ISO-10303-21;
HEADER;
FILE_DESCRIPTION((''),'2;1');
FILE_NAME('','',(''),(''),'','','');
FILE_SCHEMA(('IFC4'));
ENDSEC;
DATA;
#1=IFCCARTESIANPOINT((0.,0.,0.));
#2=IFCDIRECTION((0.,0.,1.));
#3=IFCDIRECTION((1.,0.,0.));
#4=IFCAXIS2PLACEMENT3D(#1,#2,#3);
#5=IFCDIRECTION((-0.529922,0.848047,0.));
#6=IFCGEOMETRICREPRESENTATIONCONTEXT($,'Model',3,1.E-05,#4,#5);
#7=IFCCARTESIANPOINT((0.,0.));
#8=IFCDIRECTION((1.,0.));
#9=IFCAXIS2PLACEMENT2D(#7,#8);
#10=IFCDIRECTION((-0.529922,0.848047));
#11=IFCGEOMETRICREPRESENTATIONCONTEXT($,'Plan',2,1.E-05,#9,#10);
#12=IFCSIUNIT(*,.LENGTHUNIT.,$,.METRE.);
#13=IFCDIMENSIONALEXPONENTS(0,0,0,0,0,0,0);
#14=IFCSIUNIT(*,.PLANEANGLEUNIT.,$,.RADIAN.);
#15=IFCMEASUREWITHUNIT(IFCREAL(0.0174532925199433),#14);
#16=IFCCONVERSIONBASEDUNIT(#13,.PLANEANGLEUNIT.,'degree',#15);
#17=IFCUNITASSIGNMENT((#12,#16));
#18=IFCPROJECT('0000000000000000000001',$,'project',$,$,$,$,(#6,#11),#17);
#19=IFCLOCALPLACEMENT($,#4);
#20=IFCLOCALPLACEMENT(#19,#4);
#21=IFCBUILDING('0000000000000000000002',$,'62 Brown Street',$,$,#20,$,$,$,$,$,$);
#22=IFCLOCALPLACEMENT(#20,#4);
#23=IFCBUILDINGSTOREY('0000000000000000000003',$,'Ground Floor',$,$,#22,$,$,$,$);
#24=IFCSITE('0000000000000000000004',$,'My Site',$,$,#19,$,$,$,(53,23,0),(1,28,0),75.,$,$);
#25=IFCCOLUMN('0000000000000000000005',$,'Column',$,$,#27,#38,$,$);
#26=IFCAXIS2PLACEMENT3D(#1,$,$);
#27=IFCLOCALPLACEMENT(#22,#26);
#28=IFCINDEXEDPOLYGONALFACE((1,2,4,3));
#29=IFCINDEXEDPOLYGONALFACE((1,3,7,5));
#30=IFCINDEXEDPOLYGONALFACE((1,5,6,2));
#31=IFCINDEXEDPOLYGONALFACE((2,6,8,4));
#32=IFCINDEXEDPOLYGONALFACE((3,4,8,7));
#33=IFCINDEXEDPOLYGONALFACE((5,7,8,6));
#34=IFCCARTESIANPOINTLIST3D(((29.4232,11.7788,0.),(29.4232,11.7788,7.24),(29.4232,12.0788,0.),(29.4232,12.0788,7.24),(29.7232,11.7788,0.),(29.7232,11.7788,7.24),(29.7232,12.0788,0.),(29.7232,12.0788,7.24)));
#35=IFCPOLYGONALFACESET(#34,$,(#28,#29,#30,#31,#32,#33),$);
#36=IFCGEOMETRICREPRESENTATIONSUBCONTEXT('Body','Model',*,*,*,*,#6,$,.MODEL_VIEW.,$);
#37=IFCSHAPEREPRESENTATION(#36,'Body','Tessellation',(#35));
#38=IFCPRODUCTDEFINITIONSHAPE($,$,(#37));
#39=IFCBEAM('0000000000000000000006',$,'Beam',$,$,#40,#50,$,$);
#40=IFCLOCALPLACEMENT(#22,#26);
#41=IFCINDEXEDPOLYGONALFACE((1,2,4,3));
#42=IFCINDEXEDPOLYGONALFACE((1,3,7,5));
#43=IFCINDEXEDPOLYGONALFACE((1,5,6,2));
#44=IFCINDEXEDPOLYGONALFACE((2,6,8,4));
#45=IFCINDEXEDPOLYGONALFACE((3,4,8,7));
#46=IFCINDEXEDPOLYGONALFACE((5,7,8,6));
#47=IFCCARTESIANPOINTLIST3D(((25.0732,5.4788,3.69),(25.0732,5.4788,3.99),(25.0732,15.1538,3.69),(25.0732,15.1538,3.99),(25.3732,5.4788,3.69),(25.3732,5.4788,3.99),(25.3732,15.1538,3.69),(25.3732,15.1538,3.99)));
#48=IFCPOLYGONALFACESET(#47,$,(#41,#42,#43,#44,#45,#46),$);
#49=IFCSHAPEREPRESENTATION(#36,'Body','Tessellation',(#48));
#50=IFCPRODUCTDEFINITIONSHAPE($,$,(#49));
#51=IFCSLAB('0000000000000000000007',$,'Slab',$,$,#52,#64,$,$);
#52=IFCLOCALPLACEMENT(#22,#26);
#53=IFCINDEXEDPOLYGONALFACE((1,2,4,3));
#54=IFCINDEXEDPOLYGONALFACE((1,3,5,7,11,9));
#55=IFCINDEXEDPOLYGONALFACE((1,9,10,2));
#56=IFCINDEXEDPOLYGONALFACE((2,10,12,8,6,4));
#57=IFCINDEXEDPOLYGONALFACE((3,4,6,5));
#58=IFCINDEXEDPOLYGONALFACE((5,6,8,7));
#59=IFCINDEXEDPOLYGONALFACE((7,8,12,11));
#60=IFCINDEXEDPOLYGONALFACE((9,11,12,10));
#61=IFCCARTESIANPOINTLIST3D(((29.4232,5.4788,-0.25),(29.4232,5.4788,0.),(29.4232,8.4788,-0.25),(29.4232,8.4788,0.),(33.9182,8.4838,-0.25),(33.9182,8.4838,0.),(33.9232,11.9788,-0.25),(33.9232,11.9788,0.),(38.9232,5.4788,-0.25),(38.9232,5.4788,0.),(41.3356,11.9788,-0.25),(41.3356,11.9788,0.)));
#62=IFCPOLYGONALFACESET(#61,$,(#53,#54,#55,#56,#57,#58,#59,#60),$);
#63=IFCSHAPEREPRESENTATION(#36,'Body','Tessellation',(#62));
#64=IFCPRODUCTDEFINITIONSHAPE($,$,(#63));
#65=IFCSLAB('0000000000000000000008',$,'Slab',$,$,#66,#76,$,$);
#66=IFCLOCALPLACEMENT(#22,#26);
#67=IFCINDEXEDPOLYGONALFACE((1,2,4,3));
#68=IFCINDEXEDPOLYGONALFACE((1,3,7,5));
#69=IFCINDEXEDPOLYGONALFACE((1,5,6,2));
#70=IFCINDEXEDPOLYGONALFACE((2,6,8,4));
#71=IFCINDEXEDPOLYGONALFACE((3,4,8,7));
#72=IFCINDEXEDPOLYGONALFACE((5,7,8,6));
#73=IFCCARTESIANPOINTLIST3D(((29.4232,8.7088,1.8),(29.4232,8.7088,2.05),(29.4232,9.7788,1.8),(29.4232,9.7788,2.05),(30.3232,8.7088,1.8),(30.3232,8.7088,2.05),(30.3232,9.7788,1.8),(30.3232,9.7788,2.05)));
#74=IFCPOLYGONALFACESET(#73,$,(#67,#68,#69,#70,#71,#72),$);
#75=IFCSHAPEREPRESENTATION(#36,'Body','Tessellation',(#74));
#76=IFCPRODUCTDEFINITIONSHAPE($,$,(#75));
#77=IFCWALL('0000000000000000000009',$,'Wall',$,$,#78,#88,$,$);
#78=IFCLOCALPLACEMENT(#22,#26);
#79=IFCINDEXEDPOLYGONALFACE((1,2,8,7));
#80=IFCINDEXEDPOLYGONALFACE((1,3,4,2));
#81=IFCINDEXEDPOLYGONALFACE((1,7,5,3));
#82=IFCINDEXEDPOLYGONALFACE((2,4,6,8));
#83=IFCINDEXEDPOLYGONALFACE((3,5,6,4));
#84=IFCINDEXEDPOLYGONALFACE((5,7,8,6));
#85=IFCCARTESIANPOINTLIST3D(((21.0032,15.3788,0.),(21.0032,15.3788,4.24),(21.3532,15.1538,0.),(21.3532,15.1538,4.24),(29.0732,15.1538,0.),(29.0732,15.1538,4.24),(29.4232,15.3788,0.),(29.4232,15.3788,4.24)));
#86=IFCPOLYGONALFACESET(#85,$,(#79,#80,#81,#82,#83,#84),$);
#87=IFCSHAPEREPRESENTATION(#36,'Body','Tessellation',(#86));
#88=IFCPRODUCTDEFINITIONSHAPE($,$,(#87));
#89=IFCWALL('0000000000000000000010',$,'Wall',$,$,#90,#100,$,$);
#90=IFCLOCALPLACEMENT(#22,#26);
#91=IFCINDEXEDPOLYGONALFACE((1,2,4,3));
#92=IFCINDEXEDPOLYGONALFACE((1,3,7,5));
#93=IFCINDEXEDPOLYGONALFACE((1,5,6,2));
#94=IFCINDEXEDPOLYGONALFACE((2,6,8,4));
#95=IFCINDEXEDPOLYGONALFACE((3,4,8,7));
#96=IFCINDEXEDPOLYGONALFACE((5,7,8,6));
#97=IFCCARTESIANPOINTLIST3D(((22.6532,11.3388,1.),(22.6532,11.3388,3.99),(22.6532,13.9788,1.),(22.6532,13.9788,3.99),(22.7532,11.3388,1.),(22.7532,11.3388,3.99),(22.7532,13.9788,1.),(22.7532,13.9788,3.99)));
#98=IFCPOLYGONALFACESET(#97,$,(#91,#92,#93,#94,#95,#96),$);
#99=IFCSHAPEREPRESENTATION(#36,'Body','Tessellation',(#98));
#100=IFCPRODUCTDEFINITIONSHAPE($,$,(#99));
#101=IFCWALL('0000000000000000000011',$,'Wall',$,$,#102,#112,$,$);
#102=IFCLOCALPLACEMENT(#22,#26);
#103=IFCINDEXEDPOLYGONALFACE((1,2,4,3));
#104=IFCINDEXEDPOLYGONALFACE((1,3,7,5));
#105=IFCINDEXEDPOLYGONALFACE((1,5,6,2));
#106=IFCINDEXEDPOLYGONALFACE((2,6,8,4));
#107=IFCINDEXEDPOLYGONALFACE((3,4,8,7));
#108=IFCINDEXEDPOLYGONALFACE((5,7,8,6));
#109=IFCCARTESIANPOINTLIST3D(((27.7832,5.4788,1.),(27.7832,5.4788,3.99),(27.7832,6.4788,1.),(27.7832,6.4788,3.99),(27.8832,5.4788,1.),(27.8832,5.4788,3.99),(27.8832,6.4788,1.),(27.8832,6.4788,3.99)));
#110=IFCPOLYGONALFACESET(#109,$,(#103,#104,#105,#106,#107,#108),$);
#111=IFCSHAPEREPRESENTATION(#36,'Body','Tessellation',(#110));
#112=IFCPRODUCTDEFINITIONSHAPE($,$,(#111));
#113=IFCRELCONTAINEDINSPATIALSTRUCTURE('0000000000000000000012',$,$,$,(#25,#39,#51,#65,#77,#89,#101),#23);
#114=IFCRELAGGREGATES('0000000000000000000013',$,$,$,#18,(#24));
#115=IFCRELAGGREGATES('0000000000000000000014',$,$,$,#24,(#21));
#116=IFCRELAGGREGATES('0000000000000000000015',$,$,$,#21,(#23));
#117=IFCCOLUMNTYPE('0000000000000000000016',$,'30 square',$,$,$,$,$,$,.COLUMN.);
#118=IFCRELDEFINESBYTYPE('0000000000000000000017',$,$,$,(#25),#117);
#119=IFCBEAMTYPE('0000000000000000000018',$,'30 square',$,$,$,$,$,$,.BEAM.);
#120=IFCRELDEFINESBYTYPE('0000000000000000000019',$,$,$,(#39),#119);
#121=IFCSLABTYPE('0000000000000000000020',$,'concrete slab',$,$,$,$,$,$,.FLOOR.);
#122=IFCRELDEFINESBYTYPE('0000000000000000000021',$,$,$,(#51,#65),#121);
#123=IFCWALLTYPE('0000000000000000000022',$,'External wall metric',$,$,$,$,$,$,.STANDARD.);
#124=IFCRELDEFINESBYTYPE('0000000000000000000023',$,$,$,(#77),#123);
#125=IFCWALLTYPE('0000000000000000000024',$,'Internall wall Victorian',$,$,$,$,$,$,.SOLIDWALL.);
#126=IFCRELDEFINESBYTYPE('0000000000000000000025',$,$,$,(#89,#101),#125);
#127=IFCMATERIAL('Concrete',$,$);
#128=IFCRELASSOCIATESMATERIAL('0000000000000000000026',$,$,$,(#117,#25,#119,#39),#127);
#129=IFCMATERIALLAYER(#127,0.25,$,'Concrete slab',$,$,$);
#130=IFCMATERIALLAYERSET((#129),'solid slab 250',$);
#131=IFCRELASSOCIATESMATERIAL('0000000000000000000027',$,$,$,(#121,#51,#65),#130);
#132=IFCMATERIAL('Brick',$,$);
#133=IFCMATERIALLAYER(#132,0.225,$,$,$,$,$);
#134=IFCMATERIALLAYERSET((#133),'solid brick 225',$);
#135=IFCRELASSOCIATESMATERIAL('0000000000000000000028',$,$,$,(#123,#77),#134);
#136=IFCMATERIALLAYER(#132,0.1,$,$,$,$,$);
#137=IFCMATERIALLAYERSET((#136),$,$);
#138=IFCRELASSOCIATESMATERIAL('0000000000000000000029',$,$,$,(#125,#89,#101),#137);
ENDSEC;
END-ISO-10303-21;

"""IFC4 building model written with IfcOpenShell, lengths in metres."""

from ifc_helpers import new_model, entity, si_unit, converted_unit, direction, frame, origin_with_axes, origin_2d_with_axis, place, context, subcontext, project, spatial, line, indexed_curve, rectangle, outline, extrude, clip, halfspace, material, layer, layer_set, layer_usage, material_profile, profile_set, profile_usage, type_object, element, save


model = new_model("IFC4")

# Units and contexts
model_context = context("Model", 3, precision=1e-05, world=origin_with_axes(), true_north=direction((-0.529922, 0.848047, 0.0)))
plan_context = context("Plan", 2, precision=1e-05, world=origin_2d_with_axis(), true_north=direction((-0.529922, 0.848047)))
body_context_1 = subcontext(model_context, "Body", "Model", "MODEL_VIEW")
ifc_project = project(units=[si_unit("LENGTHUNIT", "METRE"), converted_unit("PLANEANGLEUNIT", "degree", entity("IfcReal", 0.0174532925199433), si_unit("PLANEANGLEUNIT", "RADIAN"), dimensions=[0, 0, 0, 0, 0, 0, 0])], contexts=[model_context, plan_context])

# Site, building, storey
site_placement = place(None, origin_with_axes())
site = spatial("IfcSite", under=ifc_project, at=site_placement, Name="My Site", RefLatitude=(53, 23, 0), RefLongitude=(1, 28, 0), RefElevation=75.0)
building_placement = place(site_placement, origin_with_axes())
building = spatial("IfcBuilding", under=site, at=building_placement, Name="62 Brown Street")
storey_placement = place(building_placement, origin_with_axes())
storey = spatial("IfcBuildingStorey", under=building, at=storey_placement, Name="Ground Floor")

# Column
ifc_material_1 = material(Name="Concrete")
ifc_material_profile_1 = material_profile(ifc_material_1, rectangle(XDim=0.3, YDim=0.3))
ifc_profile_set_1 = profile_set([ifc_material_profile_1])
ifc_profile_usage_1 = profile_usage(ifc_profile_set_1, cardinal=5)
column_type = type_object("IfcColumnType", Name="30 square", PredefinedType="COLUMN", material=ifc_profile_set_1)
column_1_placement = place(storey_placement, frame((29.5732, 11.9288, 0.0), z_axis=(0.0, 0.0, 1.0), x_axis=(1.0, 0.0, 0.0)))
element("IfcColumn", 1, at=column_1_placement, inside=storey, type_object=column_type, material=ifc_profile_usage_1, Name="Column", context=body_context_1, shape_type="SweptSolid", body=[
    extrude(rectangle(XDim=0.3, YDim=0.3), origin_with_axes(), (0.0, 0.0, 1.0), 7.24),
])

# Beam
ifc_material_profile_2 = material_profile(ifc_material_1, rectangle(XDim=0.3, YDim=0.3))
ifc_profile_set_2 = profile_set([ifc_material_profile_2])
ifc_profile_usage_2 = profile_usage(ifc_profile_set_2, cardinal=5)
beam_type = type_object("IfcBeamType", Name="30 square", PredefinedType="BEAM", material=ifc_profile_set_2)
beam_placement = place(storey_placement, frame((25.2232, 5.4788, 3.84), z_axis=(0.0, 1.0, 0.0), x_axis=(-1.0, 0.0, 0.0)))
element("IfcBeam", 2, at=beam_placement, inside=storey, type_object=beam_type, material=ifc_profile_usage_2, Name="Beam", context=body_context_1, shape_type="SweptSolid", body=[
    extrude(rectangle(XDim=0.3, YDim=0.3), origin_with_axes(), (0.0, 0.0, 1.0), 9.675),
])

# Slabs
ifc_layer_1 = layer(ifc_material_1, 0.25, Name="Concrete slab")
ifc_layer_set_1 = layer_set([ifc_layer_1], Name="solid slab 250")
ifc_layer_usage_1 = layer_usage(ifc_layer_set_1, "AXIS3", "POSITIVE", 0.0)
slab_type_1 = type_object("IfcSlabType", Name="concrete slab", PredefinedType="FLOOR", material=ifc_layer_set_1)
slab_1_placement = place(storey_placement, frame((29.4232, 5.4788, -0.25), z_axis=(0.0, 0.0, 1.0), x_axis=(1.0, 0.0, 0.0)))
element("IfcSlab", 3, at=slab_1_placement, inside=storey, type_object=slab_type_1, material=ifc_layer_usage_1, Name="Slab", context=body_context_1, shape_type="SweptSolid", body=[
    extrude(outline(indexed_curve([(0.0, 0.0), (9.5, 0.0), (11.9124, 6.5), (0.0, 3.0), (4.5, 6.5), (4.495, 3.005)], segments=[line(1, 2), line(2, 3), line(3, 5), line(5, 6), line(6, 4), line(4, 1)], self_intersect=False)), None, (0.0, 0.0, 1.0), 0.25),
])
ifc_layer_usage_2 = layer_usage(ifc_layer_set_1, "AXIS3", "POSITIVE", 0.0)
slab_2_placement = place(storey_placement, frame((29.4232, 8.7088, 1.8), z_axis=(0.0, 0.0, 1.0), x_axis=(1.0, 0.0, 0.0)))
element("IfcSlab", 4, at=slab_2_placement, inside=storey, type_object=slab_type_1, material=ifc_layer_usage_2, Name="Slab", context=body_context_1, shape_type="SweptSolid", body=[
    extrude(outline(indexed_curve([(0.9, 1.07), (0.9, 0.0), (0.0, 0.0), (0.0, 1.07)], segments=[line(3, 2), line(2, 1), line(1, 4), line(4, 3)], self_intersect=False)), None, (0.0, 0.0, 1.0), 0.25),
])

# Walls
ifc_material_2 = material(Name="Brick")
ifc_layer_2 = layer(ifc_material_2, 0.225)
ifc_layer_set_2 = layer_set([ifc_layer_2], Name="solid brick 225")
wall_type_1 = type_object("IfcWallType", Name="External wall metric", PredefinedType="STANDARD", material=ifc_layer_set_2)
ifc_layer_usage_3 = layer_usage(ifc_layer_set_2, "AXIS2", "POSITIVE", 0.0)
wall_1_placement = place(storey_placement, frame((29.4232, 15.3788, 0.0), z_axis=(0.0, 0.0, 1.0), x_axis=(-1.0, 0.0, 0.0)))
element("IfcWall", 5, at=wall_1_placement, inside=storey, type_object=wall_type_1, material=ifc_layer_usage_3, Name="Wall", context=body_context_1, shape_type="Clipping", body=[
    clip(clip(extrude(outline(indexed_curve([(0.0, 0.0), (0.0, 0.225), (8.42, 0.225), (8.42, 0.0), (0.0, 0.0)], self_intersect=False)), origin_with_axes(), (0.0, 0.0, 1.0), 4.24), halfspace(frame((8.42, 0.0, 0.0), z_axis=(0.540756, 0.841179, 0.0), x_axis=(-0.841179, 0.540756, 0.0)), False)), halfspace(frame((0.0, 0.0, 0.0), z_axis=(-0.540758, 0.841178, 0.0), x_axis=(0.841178, 0.540758, 0.0)), False)),
])
ifc_layer_3 = layer(ifc_material_2, 0.1)
ifc_layer_set_3 = layer_set([ifc_layer_3])
ifc_layer_usage_4 = layer_usage(ifc_layer_set_3, "AXIS2", "POSITIVE", 0.0)
wall_type_2 = type_object("IfcWallType", Name="Internall wall Victorian", PredefinedType="SOLIDWALL", material=ifc_layer_set_3)
wall_2_placement = place(storey_placement, frame((22.7532, 11.3388, 1.0), z_axis=(0.0, 0.0, 1.0), x_axis=(0.0, 1.0, 0.0)))
element("IfcWall", 6, at=wall_2_placement, inside=storey, type_object=wall_type_2, material=ifc_layer_usage_4, Name="Wall", context=body_context_1, shape_type="SweptSolid", body=[
    extrude(outline(indexed_curve([(0.0, 0.0), (0.0, 0.1), (2.64, 0.1), (2.64, 0.0), (0.0, 0.0)], self_intersect=False)), origin_with_axes(), (0.0, 0.0, 1.0), 2.99),
])
ifc_layer_usage_5 = layer_usage(ifc_layer_set_3, "AXIS2", "POSITIVE", 0.0)
wall_3_placement = place(storey_placement, frame((27.8832, 5.4788, 1.0), z_axis=(0.0, 0.0, 1.0), x_axis=(0.0, 1.0, 0.0)))
element("IfcWall", 7, at=wall_3_placement, inside=storey, type_object=wall_type_2, material=ifc_layer_usage_5, Name="Wall", context=body_context_1, shape_type="SweptSolid", body=[
    extrude(outline(indexed_curve([(0.0, 0.0), (0.0, 0.1), (1.0, 0.1), (1.0, 0.0), (0.0, 0.0)], self_intersect=False)), origin_with_axes(), (0.0, 0.0, 1.0), 2.99),
])

save(model, "model.ifc")
